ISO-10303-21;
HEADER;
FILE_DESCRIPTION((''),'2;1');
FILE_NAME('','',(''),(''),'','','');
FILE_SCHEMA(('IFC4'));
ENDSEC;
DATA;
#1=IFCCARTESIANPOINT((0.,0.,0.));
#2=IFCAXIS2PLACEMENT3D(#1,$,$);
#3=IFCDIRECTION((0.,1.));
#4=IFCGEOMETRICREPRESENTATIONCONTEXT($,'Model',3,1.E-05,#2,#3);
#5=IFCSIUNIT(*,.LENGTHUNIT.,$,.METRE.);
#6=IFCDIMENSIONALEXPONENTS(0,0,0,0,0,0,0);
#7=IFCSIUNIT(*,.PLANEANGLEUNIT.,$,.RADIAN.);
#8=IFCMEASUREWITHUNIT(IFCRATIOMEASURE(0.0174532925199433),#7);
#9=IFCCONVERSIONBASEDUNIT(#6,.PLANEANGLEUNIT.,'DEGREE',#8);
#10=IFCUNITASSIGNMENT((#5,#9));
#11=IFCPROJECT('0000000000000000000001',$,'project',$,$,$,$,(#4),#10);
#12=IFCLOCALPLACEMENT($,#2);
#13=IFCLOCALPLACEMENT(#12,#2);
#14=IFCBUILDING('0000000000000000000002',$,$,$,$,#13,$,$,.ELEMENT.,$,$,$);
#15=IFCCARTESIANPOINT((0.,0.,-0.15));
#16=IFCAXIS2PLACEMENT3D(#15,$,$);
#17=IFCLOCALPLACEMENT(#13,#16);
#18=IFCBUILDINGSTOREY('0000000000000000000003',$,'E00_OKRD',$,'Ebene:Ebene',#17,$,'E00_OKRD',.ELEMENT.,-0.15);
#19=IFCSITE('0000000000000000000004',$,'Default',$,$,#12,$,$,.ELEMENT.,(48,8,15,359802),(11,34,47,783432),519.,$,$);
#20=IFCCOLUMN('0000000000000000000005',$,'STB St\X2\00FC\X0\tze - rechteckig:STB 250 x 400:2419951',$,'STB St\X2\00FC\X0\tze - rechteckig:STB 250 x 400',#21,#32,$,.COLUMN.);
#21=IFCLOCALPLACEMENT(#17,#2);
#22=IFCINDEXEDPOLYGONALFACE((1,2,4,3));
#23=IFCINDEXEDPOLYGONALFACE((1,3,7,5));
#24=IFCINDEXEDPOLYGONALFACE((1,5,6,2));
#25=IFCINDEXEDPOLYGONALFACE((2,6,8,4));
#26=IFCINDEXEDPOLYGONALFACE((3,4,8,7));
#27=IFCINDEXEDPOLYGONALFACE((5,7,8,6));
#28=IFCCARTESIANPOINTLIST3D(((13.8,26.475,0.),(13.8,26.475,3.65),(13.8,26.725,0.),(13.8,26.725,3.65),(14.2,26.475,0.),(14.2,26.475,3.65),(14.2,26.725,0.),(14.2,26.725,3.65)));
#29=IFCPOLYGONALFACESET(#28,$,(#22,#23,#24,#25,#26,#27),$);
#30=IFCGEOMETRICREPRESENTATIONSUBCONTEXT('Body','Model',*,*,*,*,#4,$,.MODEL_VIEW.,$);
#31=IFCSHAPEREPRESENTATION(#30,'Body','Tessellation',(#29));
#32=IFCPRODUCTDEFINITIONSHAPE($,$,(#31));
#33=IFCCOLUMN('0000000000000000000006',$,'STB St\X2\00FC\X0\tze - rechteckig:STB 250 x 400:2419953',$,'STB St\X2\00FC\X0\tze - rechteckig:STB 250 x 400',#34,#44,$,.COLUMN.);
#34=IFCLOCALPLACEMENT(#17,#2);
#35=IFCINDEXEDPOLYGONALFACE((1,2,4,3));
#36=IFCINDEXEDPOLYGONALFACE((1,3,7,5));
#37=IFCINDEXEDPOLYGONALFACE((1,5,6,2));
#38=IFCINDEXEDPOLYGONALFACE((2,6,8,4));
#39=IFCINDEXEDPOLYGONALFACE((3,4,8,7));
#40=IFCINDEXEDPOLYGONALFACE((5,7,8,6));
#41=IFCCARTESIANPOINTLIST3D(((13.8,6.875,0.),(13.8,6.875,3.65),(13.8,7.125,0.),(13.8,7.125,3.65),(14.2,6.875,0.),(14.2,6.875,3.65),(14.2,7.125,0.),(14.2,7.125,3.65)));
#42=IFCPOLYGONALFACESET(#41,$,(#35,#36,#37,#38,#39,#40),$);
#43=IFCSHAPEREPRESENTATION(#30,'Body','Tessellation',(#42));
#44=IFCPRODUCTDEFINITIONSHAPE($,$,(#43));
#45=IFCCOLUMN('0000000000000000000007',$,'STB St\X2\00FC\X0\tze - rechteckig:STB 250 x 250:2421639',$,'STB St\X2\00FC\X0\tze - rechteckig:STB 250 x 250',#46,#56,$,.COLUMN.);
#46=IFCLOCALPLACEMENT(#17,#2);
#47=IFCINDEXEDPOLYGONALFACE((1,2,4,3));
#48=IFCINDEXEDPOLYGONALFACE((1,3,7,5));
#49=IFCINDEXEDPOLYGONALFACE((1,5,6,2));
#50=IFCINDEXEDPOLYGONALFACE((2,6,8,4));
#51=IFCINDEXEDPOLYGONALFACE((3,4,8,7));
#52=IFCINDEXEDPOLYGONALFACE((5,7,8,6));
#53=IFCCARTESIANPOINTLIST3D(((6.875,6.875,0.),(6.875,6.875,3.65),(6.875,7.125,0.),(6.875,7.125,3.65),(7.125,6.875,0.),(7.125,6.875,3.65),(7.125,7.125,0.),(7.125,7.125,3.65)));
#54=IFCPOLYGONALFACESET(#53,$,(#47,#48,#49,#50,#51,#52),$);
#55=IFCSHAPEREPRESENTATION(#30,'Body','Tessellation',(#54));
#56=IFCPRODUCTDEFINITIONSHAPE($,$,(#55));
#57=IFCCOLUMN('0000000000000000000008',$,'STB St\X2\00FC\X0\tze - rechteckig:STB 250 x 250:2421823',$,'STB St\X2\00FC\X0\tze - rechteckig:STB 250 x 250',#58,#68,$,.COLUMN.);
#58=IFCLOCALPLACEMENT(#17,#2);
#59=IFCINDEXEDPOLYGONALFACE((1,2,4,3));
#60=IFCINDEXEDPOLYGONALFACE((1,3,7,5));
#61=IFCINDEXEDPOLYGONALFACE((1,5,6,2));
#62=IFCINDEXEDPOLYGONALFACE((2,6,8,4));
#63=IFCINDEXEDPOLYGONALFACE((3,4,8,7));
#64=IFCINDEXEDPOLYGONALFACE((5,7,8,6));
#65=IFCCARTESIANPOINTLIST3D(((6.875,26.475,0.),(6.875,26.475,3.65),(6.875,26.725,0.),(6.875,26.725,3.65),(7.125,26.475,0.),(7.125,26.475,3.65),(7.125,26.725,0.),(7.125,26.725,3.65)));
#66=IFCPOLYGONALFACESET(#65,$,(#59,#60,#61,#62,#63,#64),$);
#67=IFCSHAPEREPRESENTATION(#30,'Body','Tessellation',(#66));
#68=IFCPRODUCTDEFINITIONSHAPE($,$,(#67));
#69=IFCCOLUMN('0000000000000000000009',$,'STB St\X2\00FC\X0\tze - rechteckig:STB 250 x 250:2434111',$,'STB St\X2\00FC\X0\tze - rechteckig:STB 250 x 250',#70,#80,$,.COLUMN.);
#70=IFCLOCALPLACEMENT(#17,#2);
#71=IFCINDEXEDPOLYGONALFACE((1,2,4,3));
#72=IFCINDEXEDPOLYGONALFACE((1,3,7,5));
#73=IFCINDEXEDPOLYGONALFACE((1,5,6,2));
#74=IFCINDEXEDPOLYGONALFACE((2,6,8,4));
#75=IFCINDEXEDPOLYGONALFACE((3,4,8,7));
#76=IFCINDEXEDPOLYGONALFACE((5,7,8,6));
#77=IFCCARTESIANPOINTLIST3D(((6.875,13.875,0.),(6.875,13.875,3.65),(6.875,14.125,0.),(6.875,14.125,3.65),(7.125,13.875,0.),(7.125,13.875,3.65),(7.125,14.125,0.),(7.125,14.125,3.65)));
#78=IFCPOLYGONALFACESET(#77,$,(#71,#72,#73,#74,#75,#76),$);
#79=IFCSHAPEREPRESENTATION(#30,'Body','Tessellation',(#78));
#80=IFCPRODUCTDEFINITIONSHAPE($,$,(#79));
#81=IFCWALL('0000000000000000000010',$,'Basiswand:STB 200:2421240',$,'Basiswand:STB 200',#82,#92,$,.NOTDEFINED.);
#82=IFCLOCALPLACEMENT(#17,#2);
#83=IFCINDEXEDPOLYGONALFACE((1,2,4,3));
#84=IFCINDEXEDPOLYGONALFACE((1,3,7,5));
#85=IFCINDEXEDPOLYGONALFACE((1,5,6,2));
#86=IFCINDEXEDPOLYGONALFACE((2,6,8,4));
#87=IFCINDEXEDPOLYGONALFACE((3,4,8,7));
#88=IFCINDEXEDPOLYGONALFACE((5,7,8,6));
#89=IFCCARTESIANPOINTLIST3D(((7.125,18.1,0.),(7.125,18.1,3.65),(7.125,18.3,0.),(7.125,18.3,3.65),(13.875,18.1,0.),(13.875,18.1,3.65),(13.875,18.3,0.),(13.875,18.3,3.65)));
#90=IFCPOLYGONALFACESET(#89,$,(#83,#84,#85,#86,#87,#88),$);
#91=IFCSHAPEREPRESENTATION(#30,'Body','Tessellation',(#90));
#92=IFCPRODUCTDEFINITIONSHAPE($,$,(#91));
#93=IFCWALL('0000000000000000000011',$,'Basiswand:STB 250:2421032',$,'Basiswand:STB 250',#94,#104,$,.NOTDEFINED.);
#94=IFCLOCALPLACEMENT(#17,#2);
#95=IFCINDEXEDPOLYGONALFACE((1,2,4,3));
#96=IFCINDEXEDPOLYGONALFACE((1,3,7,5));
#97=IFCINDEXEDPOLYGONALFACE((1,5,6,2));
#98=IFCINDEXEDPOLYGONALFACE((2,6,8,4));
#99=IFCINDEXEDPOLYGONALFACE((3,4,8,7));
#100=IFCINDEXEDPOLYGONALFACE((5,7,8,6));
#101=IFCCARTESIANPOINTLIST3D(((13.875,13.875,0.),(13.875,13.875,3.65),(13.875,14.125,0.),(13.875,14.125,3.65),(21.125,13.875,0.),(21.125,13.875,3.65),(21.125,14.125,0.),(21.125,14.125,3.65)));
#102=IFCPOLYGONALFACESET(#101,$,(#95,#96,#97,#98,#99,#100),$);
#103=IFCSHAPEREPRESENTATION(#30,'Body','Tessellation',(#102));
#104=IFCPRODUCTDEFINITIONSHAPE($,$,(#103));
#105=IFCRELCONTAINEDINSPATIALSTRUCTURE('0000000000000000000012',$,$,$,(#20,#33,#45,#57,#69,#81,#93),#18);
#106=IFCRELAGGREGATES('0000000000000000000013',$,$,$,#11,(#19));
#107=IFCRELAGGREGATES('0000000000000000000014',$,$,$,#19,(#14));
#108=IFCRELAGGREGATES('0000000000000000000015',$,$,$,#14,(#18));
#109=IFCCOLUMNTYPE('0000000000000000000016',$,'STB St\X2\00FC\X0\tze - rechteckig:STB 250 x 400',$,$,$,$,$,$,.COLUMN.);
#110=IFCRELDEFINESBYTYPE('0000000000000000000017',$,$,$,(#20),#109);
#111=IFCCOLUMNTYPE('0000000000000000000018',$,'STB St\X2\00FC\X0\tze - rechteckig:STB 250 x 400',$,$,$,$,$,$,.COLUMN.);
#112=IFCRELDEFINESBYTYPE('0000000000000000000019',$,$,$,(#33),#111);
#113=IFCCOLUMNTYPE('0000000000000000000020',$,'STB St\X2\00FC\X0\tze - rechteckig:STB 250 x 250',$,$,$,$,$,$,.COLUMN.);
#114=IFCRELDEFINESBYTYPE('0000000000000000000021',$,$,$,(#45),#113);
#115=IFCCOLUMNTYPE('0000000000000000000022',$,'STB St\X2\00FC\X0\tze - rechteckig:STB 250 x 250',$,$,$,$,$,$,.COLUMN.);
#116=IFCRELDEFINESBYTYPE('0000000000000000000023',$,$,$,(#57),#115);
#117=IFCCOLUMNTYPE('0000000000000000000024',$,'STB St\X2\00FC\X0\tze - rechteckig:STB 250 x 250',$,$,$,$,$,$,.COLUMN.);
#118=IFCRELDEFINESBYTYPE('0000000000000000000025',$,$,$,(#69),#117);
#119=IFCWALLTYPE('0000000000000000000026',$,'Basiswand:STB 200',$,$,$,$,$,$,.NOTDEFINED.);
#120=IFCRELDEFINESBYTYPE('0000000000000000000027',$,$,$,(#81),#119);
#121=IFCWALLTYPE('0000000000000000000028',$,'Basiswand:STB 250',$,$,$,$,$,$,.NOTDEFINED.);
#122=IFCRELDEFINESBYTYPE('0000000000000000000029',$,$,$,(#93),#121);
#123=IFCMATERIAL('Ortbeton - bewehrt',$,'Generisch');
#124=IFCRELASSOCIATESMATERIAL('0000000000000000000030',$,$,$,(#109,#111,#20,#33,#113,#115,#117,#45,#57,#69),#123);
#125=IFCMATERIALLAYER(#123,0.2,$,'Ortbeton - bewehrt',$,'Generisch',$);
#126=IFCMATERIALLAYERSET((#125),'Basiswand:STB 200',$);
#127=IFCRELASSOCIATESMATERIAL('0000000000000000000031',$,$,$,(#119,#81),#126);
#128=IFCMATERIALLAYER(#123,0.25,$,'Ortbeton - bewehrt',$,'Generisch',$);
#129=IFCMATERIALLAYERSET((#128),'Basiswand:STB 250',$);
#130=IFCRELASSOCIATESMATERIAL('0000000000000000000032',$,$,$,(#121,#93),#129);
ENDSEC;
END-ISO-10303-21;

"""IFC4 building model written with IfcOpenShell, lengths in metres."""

from ifc_helpers import new_model, entity, si_unit, converted_unit, direction, frame, frame_2d, origin, origin_2d_with_axis, place, context, subcontext, project, spatial, rectangle, extrude, source, transform, mapped, material, layer, layer_set, layer_usage, material_profile, profile_set, profile_usage, type_object, type_shapes, element, save


model = new_model("IFC4")

# Units and contexts
model_context = context("Model", 3, precision=1e-05, world=origin(), true_north=direction((0.0, 1.0)))
body_context = subcontext(model_context, "Body", "Model", "MODEL_VIEW")
ifc_project = project(units=[si_unit("LENGTHUNIT", "METRE"), converted_unit("PLANEANGLEUNIT", "DEGREE", entity("IfcRatioMeasure", 0.0174532925199433), si_unit("PLANEANGLEUNIT", "RADIAN"), dimensions=[0, 0, 0, 0, 0, 0, 0])], contexts=[model_context])

# Site, building, storey
site_placement = place(None, frame((0.0, 0.0, 0.0)))
site = spatial("IfcSite", under=ifc_project, at=site_placement, Name="Default", CompositionType="ELEMENT", RefLatitude=(48, 8, 15, 359802), RefLongitude=(11, 34, 47, 783432), RefElevation=519.0)
building_placement = place(site_placement, origin())
building = spatial("IfcBuilding", under=site, at=building_placement, CompositionType="ELEMENT")
storey_placement = place(building_placement, frame((0.0, 0.0, -0.15)))
storey = spatial("IfcBuildingStorey", under=building, at=storey_placement, Name="E00_OKRD", ObjectType="Ebene:Ebene", LongName="E00_OKRD", CompositionType="ELEMENT", Elevation=-0.15)

# Columns
ifc_material_1 = material(Name="Ortbeton - bewehrt", Category="Generisch")
ifc_material_profile_1 = material_profile(ifc_material_1, rectangle(XDim=0.4, YDim=0.25, at=frame_2d((0.0, 0.0), x_axis=(1.0, 0.0))), Name="STB 250 x 400")
ifc_profile_set_1 = profile_set([ifc_material_profile_1], Name="STB 250 x 400")
ifc_profile_usage_1 = profile_usage(ifc_profile_set_1)
column_type_1 = type_object("IfcColumnType", Name="STB Stütze - rechteckig:STB 250 x 400", PredefinedType="COLUMN", material=ifc_profile_set_1)
shared_shape_1 = source(origin(), body_context, "Body", "SweptSolid", [
    extrude(rectangle(XDim=0.4, YDim=0.25, at=frame_2d((0.0, 0.0), x_axis=(1.0, 0.0))), frame((0.2, 0.125, 0.0), z_axis=(0.0, 0.0, 1.0), x_axis=(-1.0, 0.0, 0.0)), (0.0, 0.0, 1.0), 3.65),
])
type_shapes(column_type_1, [shared_shape_1])
column_1_placement = place(storey_placement, frame((13.8, 26.475, 0.0)))
element("IfcColumn", 1, at=column_1_placement, inside=storey, type_object=column_type_1, material=ifc_profile_usage_1, Name="STB Stütze - rechteckig:STB 250 x 400:2419951", ObjectType="STB Stütze - rechteckig:STB 250 x 400", PredefinedType="COLUMN", context=body_context, shape_type="MappedRepresentation", body=[
    mapped(shared_shape_1, transform((0.0, 0.0, 0.0), scale=1.0)),
])
ifc_profile_usage_2 = profile_usage(ifc_profile_set_1)
column_type_2 = type_object("IfcColumnType", Name="STB Stütze - rechteckig:STB 250 x 400", PredefinedType="COLUMN", material=ifc_profile_set_1)
shared_shape_2 = source(origin(), body_context, "Body", "SweptSolid", [
    extrude(rectangle(XDim=0.4, YDim=0.25, at=frame_2d((0.0, 0.0), x_axis=(1.0, 0.0))), frame((0.2, 0.125, 0.0), z_axis=(0.0, 0.0, 1.0), x_axis=(-1.0, 0.0, 0.0)), (0.0, 0.0, 1.0), 3.65),
])
type_shapes(column_type_2, [shared_shape_2])
column_2_placement = place(storey_placement, frame((13.8, 6.875, 0.0)))
element("IfcColumn", 2, at=column_2_placement, inside=storey, type_object=column_type_2, material=ifc_profile_usage_2, Name="STB Stütze - rechteckig:STB 250 x 400:2419953", ObjectType="STB Stütze - rechteckig:STB 250 x 400", PredefinedType="COLUMN", context=body_context, shape_type="MappedRepresentation", body=[
    mapped(shared_shape_2, transform((0.0, 0.0, 0.0), scale=1.0)),
])
ifc_material_profile_2 = material_profile(ifc_material_1, rectangle(XDim=0.25, YDim=0.25, at=origin_2d_with_axis()), Name="STB 250 x 250")
ifc_profile_set_2 = profile_set([ifc_material_profile_2], Name="STB 250 x 250")
ifc_profile_usage_3 = profile_usage(ifc_profile_set_2)
column_type_3 = type_object("IfcColumnType", Name="STB Stütze - rechteckig:STB 250 x 250", PredefinedType="COLUMN", material=ifc_profile_set_2)
shared_shape_3 = source(origin(), body_context, "Body", "SweptSolid", [
    extrude(rectangle(XDim=0.25, YDim=0.25, at=frame_2d((0.0, 0.0), x_axis=(1.0, 0.0))), frame((0.125, 0.125, 0.0), z_axis=(0.0, 0.0, 1.0), x_axis=(-1.0, 0.0, 0.0)), (0.0, 0.0, 1.0), 3.65),
])
type_shapes(column_type_3, [shared_shape_3])
column_3_placement = place(storey_placement, frame((6.875, 6.875, 0.0)))
element("IfcColumn", 3, at=column_3_placement, inside=storey, type_object=column_type_3, material=ifc_profile_usage_3, Name="STB Stütze - rechteckig:STB 250 x 250:2421639", ObjectType="STB Stütze - rechteckig:STB 250 x 250", PredefinedType="COLUMN", context=body_context, shape_type="MappedRepresentation", body=[
    mapped(shared_shape_3, transform((0.0, 0.0, 0.0), scale=1.0)),
])
ifc_profile_usage_4 = profile_usage(ifc_profile_set_2)
column_type_4 = type_object("IfcColumnType", Name="STB Stütze - rechteckig:STB 250 x 250", PredefinedType="COLUMN", material=ifc_profile_set_2)
shared_shape_4 = source(origin(), body_context, "Body", "SweptSolid", [
    extrude(rectangle(XDim=0.25, YDim=0.25, at=frame_2d((0.0, 0.0), x_axis=(1.0, 0.0))), frame((0.125, 0.125, 0.0), z_axis=(0.0, 0.0, 1.0), x_axis=(-1.0, 0.0, 0.0)), (0.0, 0.0, 1.0), 3.65),
])
type_shapes(column_type_4, [shared_shape_4])
column_4_placement = place(storey_placement, frame((6.875, 26.475, 0.0)))
element("IfcColumn", 4, at=column_4_placement, inside=storey, type_object=column_type_4, material=ifc_profile_usage_4, Name="STB Stütze - rechteckig:STB 250 x 250:2421823", ObjectType="STB Stütze - rechteckig:STB 250 x 250", PredefinedType="COLUMN", context=body_context, shape_type="MappedRepresentation", body=[
    mapped(shared_shape_4, transform((0.0, 0.0, 0.0), scale=1.0)),
])
ifc_profile_usage_5 = profile_usage(ifc_profile_set_2)
column_type_5 = type_object("IfcColumnType", Name="STB Stütze - rechteckig:STB 250 x 250", PredefinedType="COLUMN", material=ifc_profile_set_2)
shared_shape_5 = source(origin(), body_context, "Body", "SweptSolid", [
    extrude(rectangle(XDim=0.25, YDim=0.25, at=frame_2d((0.0, 0.0), x_axis=(1.0, 0.0))), frame((0.125, 0.125, 0.0), z_axis=(0.0, 0.0, 1.0), x_axis=(-1.0, 0.0, 0.0)), (0.0, 0.0, 1.0), 3.65),
])
type_shapes(column_type_5, [shared_shape_5])
column_5_placement = place(storey_placement, frame((6.875, 13.875, 0.0)))
element("IfcColumn", 5, at=column_5_placement, inside=storey, type_object=column_type_5, material=ifc_profile_usage_5, Name="STB Stütze - rechteckig:STB 250 x 250:2434111", ObjectType="STB Stütze - rechteckig:STB 250 x 250", PredefinedType="COLUMN", context=body_context, shape_type="MappedRepresentation", body=[
    mapped(shared_shape_5, transform((0.0, 0.0, 0.0), scale=1.0)),
])

# Walls
ifc_layer_1 = layer(ifc_material_1, 0.2, Name="Ortbeton - bewehrt", Category="Generisch")
ifc_layer_set_1 = layer_set([ifc_layer_1], Name="Basiswand:STB 200")
ifc_layer_usage_1 = layer_usage(ifc_layer_set_1, "AXIS2", "POSITIVE", -0.1)
wall_type_1 = type_object("IfcWallType", Name="Basiswand:STB 200", PredefinedType="NOTDEFINED", material=ifc_layer_set_1)
wall_1_placement = place(storey_placement, frame((7.125, 18.2, 0.0)))
element("IfcWall", 6, at=wall_1_placement, inside=storey, type_object=wall_type_1, material=ifc_layer_usage_1, Name="Basiswand:STB 200:2421240", ObjectType="Basiswand:STB 200", PredefinedType="NOTDEFINED", context=body_context, shape_type="SweptSolid", body=[
    extrude(rectangle(XDim=6.75, YDim=0.2, at=frame_2d((3.375, 0.0), x_axis=(-1.0, 0.0))), origin(), (0.0, 0.0, 1.0), 3.65),
])
ifc_layer_2 = layer(ifc_material_1, 0.25, Name="Ortbeton - bewehrt", Category="Generisch")
ifc_layer_set_2 = layer_set([ifc_layer_2], Name="Basiswand:STB 250")
ifc_layer_usage_2 = layer_usage(ifc_layer_set_2, "AXIS2", "POSITIVE", -0.125)
wall_type_2 = type_object("IfcWallType", Name="Basiswand:STB 250", PredefinedType="NOTDEFINED", material=ifc_layer_set_2)
wall_2_placement = place(storey_placement, frame((13.875, 14.0, 0.0)))
element("IfcWall", 7, at=wall_2_placement, inside=storey, type_object=wall_type_2, material=ifc_layer_usage_2, Name="Basiswand:STB 250:2421032", ObjectType="Basiswand:STB 250", PredefinedType="NOTDEFINED", context=body_context, shape_type="SweptSolid", body=[
    extrude(rectangle(XDim=7.25, YDim=0.25, at=frame_2d((3.625, 0.0), x_axis=(-1.0, 0.0))), origin(), (0.0, 0.0, 1.0), 3.65),
])

save(model, "model.ifc")
